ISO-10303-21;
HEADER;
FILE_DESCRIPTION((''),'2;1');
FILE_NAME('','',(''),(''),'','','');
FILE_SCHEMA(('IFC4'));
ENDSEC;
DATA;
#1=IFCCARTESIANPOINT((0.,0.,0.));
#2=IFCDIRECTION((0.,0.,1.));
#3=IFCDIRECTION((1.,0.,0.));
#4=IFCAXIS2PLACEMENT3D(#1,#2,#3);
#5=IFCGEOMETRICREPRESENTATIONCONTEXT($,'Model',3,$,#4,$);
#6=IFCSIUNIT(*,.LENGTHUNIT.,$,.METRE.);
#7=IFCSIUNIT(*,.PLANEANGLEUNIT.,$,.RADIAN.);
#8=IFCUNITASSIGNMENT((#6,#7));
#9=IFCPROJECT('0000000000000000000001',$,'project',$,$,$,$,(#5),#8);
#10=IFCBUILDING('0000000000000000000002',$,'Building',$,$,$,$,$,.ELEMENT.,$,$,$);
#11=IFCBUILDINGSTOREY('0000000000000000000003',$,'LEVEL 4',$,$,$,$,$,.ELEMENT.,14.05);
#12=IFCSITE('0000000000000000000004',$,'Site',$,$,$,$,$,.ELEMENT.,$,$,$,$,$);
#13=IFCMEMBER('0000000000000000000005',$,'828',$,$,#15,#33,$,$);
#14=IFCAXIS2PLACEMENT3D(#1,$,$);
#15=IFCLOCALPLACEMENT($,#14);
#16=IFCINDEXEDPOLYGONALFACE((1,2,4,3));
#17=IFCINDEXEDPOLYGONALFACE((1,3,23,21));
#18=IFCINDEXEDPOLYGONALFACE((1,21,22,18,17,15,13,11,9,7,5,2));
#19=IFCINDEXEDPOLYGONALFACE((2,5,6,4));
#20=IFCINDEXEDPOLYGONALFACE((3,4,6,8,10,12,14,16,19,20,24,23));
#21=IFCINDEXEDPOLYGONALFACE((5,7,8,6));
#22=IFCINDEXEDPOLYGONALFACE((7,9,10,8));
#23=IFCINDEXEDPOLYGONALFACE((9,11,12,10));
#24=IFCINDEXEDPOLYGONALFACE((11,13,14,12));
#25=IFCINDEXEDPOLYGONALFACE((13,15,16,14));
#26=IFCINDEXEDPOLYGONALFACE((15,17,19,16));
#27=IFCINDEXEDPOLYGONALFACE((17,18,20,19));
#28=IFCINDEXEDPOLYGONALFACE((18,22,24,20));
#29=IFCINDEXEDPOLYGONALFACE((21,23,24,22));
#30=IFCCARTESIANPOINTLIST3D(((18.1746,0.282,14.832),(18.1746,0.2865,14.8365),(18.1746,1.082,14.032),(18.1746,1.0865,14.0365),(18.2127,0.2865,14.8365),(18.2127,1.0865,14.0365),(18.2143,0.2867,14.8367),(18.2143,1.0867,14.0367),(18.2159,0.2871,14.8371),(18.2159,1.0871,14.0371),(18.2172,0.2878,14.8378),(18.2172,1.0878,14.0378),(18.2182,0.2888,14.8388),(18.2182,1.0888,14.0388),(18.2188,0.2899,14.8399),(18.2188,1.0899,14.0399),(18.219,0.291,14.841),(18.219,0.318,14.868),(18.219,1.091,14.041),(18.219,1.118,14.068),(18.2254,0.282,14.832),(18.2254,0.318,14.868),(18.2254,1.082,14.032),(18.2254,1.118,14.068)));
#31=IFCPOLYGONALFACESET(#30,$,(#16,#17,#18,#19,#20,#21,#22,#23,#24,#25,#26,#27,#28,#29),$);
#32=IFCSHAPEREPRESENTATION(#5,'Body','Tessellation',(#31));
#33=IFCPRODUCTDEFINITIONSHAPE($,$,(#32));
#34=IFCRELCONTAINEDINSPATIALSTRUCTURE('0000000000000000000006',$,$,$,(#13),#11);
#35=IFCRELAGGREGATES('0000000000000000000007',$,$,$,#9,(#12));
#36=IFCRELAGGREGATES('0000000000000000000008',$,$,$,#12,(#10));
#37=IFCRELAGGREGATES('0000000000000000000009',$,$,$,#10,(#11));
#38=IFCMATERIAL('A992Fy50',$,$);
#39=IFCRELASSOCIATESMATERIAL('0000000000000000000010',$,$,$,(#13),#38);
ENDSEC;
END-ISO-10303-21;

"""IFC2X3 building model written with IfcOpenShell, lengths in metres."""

from ifc_helpers import new_model, si_unit, frame, origin_with_axes, origin_2d_with_axis, place, context, project, spatial, l_section, extrude, material, element, save


model = new_model("IFC2X3")

# Units and contexts
model_context = context("Model", 3, world=origin_with_axes())
ifc_project = project(units=[si_unit("LENGTHUNIT", "METRE"), si_unit("PLANEANGLEUNIT", "RADIAN")], contexts=[model_context])

# Site, building, storey
site = spatial("IfcSite", under=ifc_project, Name="Site", CompositionType="ELEMENT")
building = spatial("IfcBuilding", under=site, Name="Building", CompositionType="ELEMENT")
storey = spatial("IfcBuildingStorey", under=building, Name="LEVEL 4", CompositionType="ELEMENT", Elevation=14.05)

# Shared definitions
ifc_material = material(Name="A992Fy50")

# Member
for number, where, z_axis, x_axis, name in (
    (1, (18.2, 0.3, 14.85), (0.0, 0.707107, -0.707107), (-1.0, 0.0, 0.0), "828"),
):
    element("IfcMember", number, at=place(None, frame(where, z_axis=z_axis, x_axis=x_axis)), inside=storey, material=ifc_material, Name=name, context=model_context, shape_type="SweptSolid", body=[
        extrude(l_section(Depth=0.0508, Width=0.0508, Thickness=0.0063, FilletRadius=0.0063, at=origin_2d_with_axis()), origin_with_axes(), (0.0, 0.0, 1.0), 1.1314),
    ])

save(model, "model.ifc")
